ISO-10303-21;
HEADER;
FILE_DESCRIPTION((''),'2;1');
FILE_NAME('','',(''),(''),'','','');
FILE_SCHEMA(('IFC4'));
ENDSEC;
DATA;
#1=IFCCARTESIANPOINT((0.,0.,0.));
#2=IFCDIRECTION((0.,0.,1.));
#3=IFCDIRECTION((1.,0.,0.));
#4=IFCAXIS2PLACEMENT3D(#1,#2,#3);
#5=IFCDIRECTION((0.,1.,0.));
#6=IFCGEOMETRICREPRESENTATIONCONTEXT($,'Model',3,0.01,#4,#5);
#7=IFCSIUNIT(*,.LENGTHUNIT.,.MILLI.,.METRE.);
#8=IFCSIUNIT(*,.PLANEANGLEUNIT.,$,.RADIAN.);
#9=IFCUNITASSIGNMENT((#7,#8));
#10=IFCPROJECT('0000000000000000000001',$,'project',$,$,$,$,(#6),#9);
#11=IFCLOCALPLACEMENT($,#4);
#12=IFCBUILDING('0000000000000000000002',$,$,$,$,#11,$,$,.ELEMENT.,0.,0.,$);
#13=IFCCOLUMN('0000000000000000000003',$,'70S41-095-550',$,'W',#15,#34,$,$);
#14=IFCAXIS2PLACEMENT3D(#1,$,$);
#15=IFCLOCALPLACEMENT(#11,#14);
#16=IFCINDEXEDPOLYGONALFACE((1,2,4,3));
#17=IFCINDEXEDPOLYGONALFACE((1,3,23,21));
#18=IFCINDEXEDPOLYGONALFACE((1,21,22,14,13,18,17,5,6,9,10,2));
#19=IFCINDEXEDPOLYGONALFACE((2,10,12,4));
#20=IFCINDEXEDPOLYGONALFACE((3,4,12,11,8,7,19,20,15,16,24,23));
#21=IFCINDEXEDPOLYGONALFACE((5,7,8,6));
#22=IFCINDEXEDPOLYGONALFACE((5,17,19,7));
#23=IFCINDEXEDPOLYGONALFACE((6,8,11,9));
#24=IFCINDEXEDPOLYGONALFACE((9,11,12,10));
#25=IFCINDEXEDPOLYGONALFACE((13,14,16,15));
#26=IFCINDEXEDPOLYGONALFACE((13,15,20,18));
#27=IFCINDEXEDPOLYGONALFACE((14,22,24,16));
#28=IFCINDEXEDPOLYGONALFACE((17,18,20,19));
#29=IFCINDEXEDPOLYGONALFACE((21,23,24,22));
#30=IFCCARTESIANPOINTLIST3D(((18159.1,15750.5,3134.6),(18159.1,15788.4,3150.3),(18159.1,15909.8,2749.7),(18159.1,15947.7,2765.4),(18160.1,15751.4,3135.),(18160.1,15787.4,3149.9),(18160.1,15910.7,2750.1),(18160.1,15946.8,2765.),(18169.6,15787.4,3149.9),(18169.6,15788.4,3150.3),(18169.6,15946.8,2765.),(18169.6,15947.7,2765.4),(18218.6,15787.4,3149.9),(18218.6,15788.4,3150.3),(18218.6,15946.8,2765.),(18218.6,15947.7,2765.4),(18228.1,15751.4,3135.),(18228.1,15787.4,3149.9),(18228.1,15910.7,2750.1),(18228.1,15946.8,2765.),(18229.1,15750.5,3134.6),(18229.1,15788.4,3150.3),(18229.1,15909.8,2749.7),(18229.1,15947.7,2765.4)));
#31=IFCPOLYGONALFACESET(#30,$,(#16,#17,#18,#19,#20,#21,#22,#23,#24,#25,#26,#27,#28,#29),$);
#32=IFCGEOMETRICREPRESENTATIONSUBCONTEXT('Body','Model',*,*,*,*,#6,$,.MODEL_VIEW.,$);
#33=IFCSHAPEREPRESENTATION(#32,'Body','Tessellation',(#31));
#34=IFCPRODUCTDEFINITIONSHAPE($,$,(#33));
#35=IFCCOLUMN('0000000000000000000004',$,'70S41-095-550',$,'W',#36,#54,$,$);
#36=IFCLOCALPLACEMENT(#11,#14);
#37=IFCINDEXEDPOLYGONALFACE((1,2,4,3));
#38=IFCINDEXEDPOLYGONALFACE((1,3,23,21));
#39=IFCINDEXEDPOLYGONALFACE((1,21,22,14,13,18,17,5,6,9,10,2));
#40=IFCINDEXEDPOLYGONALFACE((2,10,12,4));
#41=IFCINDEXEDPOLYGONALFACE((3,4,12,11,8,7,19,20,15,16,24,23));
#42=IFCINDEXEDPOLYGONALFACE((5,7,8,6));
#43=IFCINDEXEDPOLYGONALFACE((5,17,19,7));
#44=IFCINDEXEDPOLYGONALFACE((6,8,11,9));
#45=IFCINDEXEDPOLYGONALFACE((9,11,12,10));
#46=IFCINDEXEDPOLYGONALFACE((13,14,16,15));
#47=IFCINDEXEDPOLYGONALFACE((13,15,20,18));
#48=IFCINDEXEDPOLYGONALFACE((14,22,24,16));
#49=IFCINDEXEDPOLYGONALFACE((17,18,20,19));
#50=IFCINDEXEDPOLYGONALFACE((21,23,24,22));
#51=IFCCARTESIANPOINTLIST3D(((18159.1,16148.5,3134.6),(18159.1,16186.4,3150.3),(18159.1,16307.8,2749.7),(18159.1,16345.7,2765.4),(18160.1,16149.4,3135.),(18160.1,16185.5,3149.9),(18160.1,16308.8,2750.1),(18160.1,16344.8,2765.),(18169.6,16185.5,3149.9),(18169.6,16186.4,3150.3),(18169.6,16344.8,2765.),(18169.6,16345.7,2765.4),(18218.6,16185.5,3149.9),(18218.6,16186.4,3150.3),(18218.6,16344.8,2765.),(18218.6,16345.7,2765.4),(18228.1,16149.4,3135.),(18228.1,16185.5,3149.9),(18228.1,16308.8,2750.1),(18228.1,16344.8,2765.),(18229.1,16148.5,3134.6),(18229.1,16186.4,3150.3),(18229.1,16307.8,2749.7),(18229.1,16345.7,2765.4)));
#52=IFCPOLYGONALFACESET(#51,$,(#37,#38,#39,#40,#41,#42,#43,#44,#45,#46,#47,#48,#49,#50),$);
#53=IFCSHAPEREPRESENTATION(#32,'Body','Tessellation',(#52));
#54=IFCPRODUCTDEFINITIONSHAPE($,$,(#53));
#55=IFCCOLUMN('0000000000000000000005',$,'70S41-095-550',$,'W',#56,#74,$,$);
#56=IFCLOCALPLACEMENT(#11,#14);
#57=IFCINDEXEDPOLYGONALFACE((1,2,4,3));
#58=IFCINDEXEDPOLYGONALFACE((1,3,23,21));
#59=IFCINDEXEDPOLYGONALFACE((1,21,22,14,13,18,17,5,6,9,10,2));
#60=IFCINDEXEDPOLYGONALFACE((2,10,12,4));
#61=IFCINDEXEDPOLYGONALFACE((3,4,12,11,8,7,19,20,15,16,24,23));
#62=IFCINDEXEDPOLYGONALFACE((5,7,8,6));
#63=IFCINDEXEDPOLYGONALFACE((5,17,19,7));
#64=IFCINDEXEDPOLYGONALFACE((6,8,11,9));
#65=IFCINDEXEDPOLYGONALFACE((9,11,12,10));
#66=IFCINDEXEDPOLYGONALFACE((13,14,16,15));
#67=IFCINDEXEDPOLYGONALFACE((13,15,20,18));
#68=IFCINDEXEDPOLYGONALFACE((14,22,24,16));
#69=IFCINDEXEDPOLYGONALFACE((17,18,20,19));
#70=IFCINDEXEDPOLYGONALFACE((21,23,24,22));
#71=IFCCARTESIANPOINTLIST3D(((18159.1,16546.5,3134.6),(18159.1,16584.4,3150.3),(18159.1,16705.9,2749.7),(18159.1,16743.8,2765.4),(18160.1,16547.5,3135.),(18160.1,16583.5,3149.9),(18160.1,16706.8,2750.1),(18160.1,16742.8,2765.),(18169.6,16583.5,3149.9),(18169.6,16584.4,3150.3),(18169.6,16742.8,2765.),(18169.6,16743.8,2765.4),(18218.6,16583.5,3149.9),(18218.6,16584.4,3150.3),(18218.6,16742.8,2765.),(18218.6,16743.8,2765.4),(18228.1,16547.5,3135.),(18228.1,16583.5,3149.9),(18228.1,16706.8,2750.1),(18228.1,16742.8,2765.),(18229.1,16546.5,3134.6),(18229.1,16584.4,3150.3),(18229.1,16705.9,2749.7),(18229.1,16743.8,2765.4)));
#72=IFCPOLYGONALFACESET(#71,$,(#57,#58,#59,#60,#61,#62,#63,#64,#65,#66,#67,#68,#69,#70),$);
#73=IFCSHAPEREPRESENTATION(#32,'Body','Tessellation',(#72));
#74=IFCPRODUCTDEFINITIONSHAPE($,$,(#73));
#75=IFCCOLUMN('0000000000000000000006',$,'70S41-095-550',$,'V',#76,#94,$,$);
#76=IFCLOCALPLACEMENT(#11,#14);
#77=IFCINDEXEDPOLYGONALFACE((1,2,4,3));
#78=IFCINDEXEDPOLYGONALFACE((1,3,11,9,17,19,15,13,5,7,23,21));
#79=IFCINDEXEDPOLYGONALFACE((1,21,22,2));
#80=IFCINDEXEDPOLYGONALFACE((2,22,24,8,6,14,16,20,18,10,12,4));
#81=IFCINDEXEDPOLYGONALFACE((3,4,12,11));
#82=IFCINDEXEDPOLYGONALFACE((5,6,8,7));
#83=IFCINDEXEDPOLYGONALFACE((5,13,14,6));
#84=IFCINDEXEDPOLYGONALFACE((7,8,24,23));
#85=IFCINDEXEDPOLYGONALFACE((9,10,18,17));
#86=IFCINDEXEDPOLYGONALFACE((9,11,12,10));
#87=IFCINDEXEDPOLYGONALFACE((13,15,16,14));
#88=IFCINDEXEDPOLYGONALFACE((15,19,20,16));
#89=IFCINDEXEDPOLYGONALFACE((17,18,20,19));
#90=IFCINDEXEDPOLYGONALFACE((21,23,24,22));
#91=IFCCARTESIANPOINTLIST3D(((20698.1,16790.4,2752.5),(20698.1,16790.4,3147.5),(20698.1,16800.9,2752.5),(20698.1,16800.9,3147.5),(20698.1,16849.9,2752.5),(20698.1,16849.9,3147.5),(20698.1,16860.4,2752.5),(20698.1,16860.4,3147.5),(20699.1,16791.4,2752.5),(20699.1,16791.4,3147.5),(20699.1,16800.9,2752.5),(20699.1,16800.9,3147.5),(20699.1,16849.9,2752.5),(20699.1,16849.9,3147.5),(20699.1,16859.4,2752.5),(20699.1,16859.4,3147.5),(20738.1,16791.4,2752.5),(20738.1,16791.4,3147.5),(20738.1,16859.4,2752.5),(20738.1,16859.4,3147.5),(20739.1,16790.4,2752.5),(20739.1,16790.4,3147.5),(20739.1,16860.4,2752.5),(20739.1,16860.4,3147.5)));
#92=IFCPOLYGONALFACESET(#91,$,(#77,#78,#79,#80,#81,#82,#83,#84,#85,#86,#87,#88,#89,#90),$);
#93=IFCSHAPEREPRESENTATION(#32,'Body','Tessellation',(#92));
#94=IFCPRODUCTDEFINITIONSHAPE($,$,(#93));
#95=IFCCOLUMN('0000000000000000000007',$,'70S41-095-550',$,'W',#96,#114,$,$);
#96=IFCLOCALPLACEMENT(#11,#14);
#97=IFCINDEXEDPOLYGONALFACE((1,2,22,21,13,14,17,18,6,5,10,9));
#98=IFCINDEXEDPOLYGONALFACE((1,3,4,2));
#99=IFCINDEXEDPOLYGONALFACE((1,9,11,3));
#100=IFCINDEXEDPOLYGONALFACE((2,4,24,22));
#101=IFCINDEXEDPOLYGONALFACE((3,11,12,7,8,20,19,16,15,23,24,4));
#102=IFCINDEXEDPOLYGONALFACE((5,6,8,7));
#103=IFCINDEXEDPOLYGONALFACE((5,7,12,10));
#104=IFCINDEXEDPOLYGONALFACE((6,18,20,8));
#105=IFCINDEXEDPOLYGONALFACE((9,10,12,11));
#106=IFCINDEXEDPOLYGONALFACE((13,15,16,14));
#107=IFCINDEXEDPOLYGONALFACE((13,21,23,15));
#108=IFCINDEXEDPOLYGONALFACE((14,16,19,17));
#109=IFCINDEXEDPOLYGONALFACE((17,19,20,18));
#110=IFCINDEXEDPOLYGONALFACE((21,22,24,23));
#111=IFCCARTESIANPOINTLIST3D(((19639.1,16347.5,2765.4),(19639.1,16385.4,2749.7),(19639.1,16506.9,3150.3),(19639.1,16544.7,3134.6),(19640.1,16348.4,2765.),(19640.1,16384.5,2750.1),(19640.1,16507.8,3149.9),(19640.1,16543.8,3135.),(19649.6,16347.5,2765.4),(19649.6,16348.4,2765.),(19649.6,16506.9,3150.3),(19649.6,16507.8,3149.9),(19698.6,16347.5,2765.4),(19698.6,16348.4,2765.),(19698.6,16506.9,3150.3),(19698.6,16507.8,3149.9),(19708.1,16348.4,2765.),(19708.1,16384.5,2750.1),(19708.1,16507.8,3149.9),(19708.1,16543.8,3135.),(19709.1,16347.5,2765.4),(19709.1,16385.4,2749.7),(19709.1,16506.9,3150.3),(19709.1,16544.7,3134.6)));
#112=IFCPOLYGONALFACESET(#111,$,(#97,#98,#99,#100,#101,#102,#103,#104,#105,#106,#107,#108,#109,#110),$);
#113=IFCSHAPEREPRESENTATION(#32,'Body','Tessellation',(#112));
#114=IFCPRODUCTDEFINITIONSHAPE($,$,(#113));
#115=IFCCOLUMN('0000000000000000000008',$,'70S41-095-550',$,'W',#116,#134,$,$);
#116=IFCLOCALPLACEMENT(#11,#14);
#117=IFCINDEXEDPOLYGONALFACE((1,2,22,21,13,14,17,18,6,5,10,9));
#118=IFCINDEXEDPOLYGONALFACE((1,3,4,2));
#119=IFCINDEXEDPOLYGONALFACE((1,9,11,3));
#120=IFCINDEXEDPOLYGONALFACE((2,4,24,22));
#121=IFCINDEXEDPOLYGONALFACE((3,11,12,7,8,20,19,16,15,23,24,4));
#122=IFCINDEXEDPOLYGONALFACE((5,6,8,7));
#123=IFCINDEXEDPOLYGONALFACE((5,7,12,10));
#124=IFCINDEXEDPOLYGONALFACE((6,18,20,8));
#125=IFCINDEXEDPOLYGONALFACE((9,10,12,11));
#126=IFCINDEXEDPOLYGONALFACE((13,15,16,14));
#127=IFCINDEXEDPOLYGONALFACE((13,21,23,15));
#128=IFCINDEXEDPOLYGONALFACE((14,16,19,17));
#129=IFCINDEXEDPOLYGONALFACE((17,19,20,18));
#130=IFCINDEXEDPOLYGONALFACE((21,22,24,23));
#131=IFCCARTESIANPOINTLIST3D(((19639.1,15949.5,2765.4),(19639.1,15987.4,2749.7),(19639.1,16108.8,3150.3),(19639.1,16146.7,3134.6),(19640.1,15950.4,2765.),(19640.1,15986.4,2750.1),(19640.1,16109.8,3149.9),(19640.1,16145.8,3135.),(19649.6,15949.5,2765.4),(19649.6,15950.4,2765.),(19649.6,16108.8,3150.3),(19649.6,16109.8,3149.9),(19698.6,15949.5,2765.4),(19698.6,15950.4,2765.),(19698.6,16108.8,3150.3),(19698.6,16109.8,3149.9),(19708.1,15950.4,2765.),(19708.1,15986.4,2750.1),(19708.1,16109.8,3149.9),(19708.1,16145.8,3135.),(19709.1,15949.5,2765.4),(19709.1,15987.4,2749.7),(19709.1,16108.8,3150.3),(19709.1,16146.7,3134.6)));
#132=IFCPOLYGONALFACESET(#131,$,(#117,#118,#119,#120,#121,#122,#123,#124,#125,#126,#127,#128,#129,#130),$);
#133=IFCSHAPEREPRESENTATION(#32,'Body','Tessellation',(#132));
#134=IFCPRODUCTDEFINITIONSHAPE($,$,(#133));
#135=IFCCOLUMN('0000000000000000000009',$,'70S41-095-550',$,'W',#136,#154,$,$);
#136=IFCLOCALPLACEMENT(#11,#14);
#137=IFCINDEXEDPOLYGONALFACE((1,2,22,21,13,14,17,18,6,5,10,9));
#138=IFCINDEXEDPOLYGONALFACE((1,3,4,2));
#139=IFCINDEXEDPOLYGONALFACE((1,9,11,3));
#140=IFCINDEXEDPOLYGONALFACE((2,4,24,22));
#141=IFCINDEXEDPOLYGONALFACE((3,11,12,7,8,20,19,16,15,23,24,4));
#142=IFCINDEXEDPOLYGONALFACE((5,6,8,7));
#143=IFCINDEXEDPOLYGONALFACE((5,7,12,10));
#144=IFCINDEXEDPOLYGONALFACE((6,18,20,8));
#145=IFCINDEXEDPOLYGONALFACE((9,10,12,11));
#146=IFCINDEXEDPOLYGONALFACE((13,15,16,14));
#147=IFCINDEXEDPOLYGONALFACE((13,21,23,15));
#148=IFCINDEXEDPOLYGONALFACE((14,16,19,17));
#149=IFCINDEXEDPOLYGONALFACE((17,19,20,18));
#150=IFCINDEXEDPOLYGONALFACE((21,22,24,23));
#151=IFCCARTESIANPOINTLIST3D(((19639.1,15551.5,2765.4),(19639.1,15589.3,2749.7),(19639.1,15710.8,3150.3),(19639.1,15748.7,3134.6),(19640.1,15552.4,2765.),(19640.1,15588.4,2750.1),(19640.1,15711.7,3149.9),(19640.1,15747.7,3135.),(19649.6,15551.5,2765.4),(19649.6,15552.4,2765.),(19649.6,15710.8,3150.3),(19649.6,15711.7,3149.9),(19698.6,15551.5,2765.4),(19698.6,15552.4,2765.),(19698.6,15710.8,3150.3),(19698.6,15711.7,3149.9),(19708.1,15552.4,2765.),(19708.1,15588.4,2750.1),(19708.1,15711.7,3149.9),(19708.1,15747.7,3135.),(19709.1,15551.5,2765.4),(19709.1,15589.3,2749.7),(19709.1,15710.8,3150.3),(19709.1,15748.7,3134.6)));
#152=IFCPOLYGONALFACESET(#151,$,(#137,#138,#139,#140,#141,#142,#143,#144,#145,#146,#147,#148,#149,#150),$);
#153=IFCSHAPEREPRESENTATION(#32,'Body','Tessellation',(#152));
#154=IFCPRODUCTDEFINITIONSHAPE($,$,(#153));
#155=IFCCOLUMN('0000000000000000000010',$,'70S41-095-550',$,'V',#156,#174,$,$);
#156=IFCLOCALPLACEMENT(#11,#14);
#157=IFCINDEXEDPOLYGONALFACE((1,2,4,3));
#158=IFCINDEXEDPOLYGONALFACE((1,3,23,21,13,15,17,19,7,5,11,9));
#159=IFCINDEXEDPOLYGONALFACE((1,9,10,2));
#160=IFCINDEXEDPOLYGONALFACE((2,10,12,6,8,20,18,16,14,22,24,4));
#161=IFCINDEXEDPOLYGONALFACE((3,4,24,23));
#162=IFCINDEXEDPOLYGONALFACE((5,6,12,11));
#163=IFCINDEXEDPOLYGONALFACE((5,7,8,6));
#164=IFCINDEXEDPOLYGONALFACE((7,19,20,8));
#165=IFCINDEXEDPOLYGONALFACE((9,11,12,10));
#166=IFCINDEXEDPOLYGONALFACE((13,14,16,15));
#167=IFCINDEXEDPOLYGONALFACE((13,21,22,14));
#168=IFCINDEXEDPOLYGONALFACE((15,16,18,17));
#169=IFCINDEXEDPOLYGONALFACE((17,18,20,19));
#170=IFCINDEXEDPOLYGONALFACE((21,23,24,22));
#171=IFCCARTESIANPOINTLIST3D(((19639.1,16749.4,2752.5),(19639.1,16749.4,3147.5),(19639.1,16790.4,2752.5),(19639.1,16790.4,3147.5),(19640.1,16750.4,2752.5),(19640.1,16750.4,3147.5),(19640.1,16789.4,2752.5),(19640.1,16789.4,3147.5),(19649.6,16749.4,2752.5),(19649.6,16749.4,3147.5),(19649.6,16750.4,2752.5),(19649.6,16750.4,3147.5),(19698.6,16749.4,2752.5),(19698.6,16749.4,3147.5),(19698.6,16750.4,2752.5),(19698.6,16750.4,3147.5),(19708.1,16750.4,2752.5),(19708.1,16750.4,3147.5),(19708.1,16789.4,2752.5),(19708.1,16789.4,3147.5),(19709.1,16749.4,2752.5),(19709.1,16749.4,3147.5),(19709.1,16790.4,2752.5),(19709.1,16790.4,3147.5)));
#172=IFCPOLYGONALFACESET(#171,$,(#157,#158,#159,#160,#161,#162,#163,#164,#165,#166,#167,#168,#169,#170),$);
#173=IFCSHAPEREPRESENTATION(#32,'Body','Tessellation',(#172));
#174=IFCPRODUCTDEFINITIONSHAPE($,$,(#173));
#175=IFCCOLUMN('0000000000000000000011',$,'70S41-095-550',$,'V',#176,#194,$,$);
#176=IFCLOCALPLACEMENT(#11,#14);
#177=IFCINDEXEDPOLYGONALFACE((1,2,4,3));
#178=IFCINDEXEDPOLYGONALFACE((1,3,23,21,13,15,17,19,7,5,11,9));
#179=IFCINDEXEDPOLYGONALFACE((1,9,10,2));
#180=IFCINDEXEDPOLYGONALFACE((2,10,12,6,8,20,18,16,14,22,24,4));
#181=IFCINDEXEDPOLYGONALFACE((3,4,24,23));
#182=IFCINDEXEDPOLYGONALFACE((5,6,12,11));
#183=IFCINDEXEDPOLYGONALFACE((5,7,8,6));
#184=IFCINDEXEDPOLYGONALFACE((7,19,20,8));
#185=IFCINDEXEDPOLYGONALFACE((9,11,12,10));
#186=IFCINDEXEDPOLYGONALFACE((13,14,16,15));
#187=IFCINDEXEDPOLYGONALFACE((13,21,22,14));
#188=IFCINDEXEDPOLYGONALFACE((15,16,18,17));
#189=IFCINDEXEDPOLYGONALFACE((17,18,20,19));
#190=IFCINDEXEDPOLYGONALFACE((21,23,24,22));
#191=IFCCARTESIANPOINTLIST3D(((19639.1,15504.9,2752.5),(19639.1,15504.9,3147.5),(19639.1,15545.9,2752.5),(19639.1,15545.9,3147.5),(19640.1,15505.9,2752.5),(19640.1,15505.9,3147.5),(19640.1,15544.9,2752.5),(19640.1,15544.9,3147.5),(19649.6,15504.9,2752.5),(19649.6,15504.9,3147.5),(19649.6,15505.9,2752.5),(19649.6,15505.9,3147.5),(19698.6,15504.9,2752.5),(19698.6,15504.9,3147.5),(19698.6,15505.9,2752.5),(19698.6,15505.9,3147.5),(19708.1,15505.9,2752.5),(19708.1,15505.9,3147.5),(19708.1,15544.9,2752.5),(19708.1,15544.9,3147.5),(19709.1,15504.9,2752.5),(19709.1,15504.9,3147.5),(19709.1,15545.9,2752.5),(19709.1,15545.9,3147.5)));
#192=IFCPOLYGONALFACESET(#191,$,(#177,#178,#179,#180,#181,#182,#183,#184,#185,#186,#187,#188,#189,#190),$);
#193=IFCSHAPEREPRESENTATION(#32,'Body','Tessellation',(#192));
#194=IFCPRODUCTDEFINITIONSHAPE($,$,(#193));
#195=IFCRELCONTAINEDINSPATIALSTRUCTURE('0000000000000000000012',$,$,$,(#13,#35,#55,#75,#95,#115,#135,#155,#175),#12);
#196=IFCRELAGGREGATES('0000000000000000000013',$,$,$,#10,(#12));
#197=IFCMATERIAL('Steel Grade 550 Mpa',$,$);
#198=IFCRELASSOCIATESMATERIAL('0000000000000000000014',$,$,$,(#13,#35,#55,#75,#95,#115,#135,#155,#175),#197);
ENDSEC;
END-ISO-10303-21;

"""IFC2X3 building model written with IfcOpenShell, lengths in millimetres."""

from ifc_helpers import new_model, si_unit, direction, frame, origin, origin_with_axes, origin_2d_with_axis, place, context, subcontext, project, spatial, c_section, extrude, source, transform, mapped, material, element, save


model = new_model("IFC2X3")

# Units and contexts
model_context = context("Model", 3, precision=0.01, world=origin_with_axes(), true_north=direction((0.0, 1.0, 0.0)))
body_context = subcontext(model_context, "Body", "Model", "MODEL_VIEW")
ifc_project = project(units=[si_unit("LENGTHUNIT", "METRE", prefix="MILLI"), si_unit("PLANEANGLEUNIT", "RADIAN")], contexts=[model_context])

# Building
building_placement = place(None, origin_with_axes())
building = spatial("IfcBuilding", under=ifc_project, at=building_placement, CompositionType="ELEMENT", ElevationOfRefHeight=0.0, ElevationOfTerrain=0.0)

# Columns
ifc_material = material(Name="Steel Grade 550 Mpa")
shared_shape_1 = source(origin(), body_context, "Body", "SweptSolid", [
    extrude(c_section(Depth=70.0, Width=41.0, WallThickness=1.0, Girth=10.5, at=origin_2d_with_axis()), origin_with_axes(), (0.0, 0.0, 1.0), 416.6),
])
column_1_placement = place(None, frame((18194.1, 15928.8, 2757.6), z_axis=(0.0, -0.382523, 0.923946), x_axis=(0.0, 0.923946, 0.382523)))
element("IfcColumn", 1, at=column_1_placement, inside=building, material=ifc_material, Name="70S41-095-550", ObjectType="W", context=body_context, shape_type="MappedRepresentation", body=[
    mapped(shared_shape_1, transform((0.0, 0.0, 0.0), scale=1.0)),
])
shared_shape_2 = source(origin(), body_context, "Body", "SweptSolid", [
    extrude(c_section(Depth=70.0, Width=41.0, WallThickness=1.0, Girth=10.5, at=origin_2d_with_axis()), origin_with_axes(), (0.0, 0.0, 1.0), 416.6),
])
column_2_placement = place(None, frame((18194.1, 16326.8, 2757.6), z_axis=(0.0, -0.382523, 0.923946), x_axis=(0.0, 0.923946, 0.382523)))
element("IfcColumn", 2, at=column_2_placement, inside=building, material=ifc_material, Name="70S41-095-550", ObjectType="W", context=body_context, shape_type="MappedRepresentation", body=[
    mapped(shared_shape_2, transform((0.0, 0.0, 0.0), scale=1.0)),
])
shared_shape_3 = source(origin(), body_context, "Body", "SweptSolid", [
    extrude(c_section(Depth=70.0, Width=41.0, WallThickness=1.0, Girth=10.5, at=origin_2d_with_axis()), origin_with_axes(), (0.0, 0.0, 1.0), 416.6),
])
column_3_placement = place(None, frame((18194.1, 16724.8, 2757.6), z_axis=(0.0, -0.382523, 0.923946), x_axis=(0.0, 0.923946, 0.382523)))
element("IfcColumn", 3, at=column_3_placement, inside=building, material=ifc_material, Name="70S41-095-550", ObjectType="W", context=body_context, shape_type="MappedRepresentation", body=[
    mapped(shared_shape_3, transform((0.0, 0.0, 0.0), scale=1.0)),
])
shared_shape_4 = source(origin(), body_context, "Body", "SweptSolid", [
    extrude(c_section(Depth=70.0, Width=41.0, WallThickness=1.0, Girth=10.5, at=origin_2d_with_axis()), origin_with_axes(), (0.0, 0.0, 1.0), 395.0),
])
column_4_placement = place(None, frame((20718.6, 16825.4, 2752.5), z_axis=(0.0, 0.0, 1.0), x_axis=(-1.0, 0.0, 0.0)))
element("IfcColumn", 4, at=column_4_placement, inside=building, material=ifc_material, Name="70S41-095-550", ObjectType="V", context=body_context, shape_type="MappedRepresentation", body=[
    mapped(shared_shape_4, transform((0.0, 0.0, 0.0), scale=1.0)),
])
shared_shape_5 = source(origin(), body_context, "Body", "SweptSolid", [
    extrude(c_section(Depth=70.0, Width=41.0, WallThickness=1.0, Girth=10.5, at=origin_2d_with_axis()), origin_with_axes(), (0.0, 0.0, 1.0), 416.6),
])
column_5_placement = place(None, frame((19674.1, 16366.5, 2757.6), z_axis=(0.0, 0.382523, 0.923946), x_axis=(0.0, -0.923946, 0.382523)))
element("IfcColumn", 5, at=column_5_placement, inside=building, material=ifc_material, Name="70S41-095-550", ObjectType="W", context=body_context, shape_type="MappedRepresentation", body=[
    mapped(shared_shape_5, transform((0.0, 0.0, 0.0), scale=1.0)),
])
shared_shape_6 = source(origin(), body_context, "Body", "SweptSolid", [
    extrude(c_section(Depth=70.0, Width=41.0, WallThickness=1.0, Girth=10.5, at=origin_2d_with_axis()), origin_with_axes(), (0.0, 0.0, 1.0), 416.6),
])
column_6_placement = place(None, frame((19674.1, 15968.4, 2757.6), z_axis=(0.0, 0.382523, 0.923946), x_axis=(0.0, -0.923946, 0.382523)))
element("IfcColumn", 6, at=column_6_placement, inside=building, material=ifc_material, Name="70S41-095-550", ObjectType="W", context=body_context, shape_type="MappedRepresentation", body=[
    mapped(shared_shape_6, transform((0.0, 0.0, 0.0), scale=1.0)),
])
shared_shape_7 = source(origin(), body_context, "Body", "SweptSolid", [
    extrude(c_section(Depth=70.0, Width=41.0, WallThickness=1.0, Girth=10.5, at=origin_2d_with_axis()), origin_with_axes(), (0.0, 0.0, 1.0), 416.6),
])
column_7_placement = place(None, frame((19674.1, 15570.4, 2757.6), z_axis=(0.0, 0.382523, 0.923946), x_axis=(0.0, -0.923946, 0.382523)))
element("IfcColumn", 7, at=column_7_placement, inside=building, material=ifc_material, Name="70S41-095-550", ObjectType="W", context=body_context, shape_type="MappedRepresentation", body=[
    mapped(shared_shape_7, transform((0.0, 0.0, 0.0), scale=1.0)),
])
shared_shape_8 = source(origin(), body_context, "Body", "SweptSolid", [
    extrude(c_section(Depth=70.0, Width=41.0, WallThickness=1.0, Girth=10.5, at=origin_2d_with_axis()), origin_with_axes(), (0.0, 0.0, 1.0), 395.0),
])
column_8_placement = place(None, frame((19674.1, 16769.9, 2752.5), z_axis=(0.0, 0.0, 1.0), x_axis=(0.0, -1.0, 0.0)))
element("IfcColumn", 8, at=column_8_placement, inside=building, material=ifc_material, Name="70S41-095-550", ObjectType="V", context=body_context, shape_type="MappedRepresentation", body=[
    mapped(shared_shape_8, transform((0.0, 0.0, 0.0), scale=1.0)),
])
shared_shape_9 = source(origin(), body_context, "Body", "SweptSolid", [
    extrude(c_section(Depth=70.0, Width=41.0, WallThickness=1.0, Girth=10.5, at=origin_2d_with_axis()), origin_with_axes(), (0.0, 0.0, 1.0), 395.0),
])
column_9_placement = place(None, frame((19674.1, 15525.4, 2752.5), z_axis=(0.0, 0.0, 1.0), x_axis=(0.0, -1.0, 0.0)))
element("IfcColumn", 9, at=column_9_placement, inside=building, material=ifc_material, Name="70S41-095-550", ObjectType="V", context=body_context, shape_type="MappedRepresentation", body=[
    mapped(shared_shape_9, transform((0.0, 0.0, 0.0), scale=1.0)),
])

save(model, "model.ifc")
